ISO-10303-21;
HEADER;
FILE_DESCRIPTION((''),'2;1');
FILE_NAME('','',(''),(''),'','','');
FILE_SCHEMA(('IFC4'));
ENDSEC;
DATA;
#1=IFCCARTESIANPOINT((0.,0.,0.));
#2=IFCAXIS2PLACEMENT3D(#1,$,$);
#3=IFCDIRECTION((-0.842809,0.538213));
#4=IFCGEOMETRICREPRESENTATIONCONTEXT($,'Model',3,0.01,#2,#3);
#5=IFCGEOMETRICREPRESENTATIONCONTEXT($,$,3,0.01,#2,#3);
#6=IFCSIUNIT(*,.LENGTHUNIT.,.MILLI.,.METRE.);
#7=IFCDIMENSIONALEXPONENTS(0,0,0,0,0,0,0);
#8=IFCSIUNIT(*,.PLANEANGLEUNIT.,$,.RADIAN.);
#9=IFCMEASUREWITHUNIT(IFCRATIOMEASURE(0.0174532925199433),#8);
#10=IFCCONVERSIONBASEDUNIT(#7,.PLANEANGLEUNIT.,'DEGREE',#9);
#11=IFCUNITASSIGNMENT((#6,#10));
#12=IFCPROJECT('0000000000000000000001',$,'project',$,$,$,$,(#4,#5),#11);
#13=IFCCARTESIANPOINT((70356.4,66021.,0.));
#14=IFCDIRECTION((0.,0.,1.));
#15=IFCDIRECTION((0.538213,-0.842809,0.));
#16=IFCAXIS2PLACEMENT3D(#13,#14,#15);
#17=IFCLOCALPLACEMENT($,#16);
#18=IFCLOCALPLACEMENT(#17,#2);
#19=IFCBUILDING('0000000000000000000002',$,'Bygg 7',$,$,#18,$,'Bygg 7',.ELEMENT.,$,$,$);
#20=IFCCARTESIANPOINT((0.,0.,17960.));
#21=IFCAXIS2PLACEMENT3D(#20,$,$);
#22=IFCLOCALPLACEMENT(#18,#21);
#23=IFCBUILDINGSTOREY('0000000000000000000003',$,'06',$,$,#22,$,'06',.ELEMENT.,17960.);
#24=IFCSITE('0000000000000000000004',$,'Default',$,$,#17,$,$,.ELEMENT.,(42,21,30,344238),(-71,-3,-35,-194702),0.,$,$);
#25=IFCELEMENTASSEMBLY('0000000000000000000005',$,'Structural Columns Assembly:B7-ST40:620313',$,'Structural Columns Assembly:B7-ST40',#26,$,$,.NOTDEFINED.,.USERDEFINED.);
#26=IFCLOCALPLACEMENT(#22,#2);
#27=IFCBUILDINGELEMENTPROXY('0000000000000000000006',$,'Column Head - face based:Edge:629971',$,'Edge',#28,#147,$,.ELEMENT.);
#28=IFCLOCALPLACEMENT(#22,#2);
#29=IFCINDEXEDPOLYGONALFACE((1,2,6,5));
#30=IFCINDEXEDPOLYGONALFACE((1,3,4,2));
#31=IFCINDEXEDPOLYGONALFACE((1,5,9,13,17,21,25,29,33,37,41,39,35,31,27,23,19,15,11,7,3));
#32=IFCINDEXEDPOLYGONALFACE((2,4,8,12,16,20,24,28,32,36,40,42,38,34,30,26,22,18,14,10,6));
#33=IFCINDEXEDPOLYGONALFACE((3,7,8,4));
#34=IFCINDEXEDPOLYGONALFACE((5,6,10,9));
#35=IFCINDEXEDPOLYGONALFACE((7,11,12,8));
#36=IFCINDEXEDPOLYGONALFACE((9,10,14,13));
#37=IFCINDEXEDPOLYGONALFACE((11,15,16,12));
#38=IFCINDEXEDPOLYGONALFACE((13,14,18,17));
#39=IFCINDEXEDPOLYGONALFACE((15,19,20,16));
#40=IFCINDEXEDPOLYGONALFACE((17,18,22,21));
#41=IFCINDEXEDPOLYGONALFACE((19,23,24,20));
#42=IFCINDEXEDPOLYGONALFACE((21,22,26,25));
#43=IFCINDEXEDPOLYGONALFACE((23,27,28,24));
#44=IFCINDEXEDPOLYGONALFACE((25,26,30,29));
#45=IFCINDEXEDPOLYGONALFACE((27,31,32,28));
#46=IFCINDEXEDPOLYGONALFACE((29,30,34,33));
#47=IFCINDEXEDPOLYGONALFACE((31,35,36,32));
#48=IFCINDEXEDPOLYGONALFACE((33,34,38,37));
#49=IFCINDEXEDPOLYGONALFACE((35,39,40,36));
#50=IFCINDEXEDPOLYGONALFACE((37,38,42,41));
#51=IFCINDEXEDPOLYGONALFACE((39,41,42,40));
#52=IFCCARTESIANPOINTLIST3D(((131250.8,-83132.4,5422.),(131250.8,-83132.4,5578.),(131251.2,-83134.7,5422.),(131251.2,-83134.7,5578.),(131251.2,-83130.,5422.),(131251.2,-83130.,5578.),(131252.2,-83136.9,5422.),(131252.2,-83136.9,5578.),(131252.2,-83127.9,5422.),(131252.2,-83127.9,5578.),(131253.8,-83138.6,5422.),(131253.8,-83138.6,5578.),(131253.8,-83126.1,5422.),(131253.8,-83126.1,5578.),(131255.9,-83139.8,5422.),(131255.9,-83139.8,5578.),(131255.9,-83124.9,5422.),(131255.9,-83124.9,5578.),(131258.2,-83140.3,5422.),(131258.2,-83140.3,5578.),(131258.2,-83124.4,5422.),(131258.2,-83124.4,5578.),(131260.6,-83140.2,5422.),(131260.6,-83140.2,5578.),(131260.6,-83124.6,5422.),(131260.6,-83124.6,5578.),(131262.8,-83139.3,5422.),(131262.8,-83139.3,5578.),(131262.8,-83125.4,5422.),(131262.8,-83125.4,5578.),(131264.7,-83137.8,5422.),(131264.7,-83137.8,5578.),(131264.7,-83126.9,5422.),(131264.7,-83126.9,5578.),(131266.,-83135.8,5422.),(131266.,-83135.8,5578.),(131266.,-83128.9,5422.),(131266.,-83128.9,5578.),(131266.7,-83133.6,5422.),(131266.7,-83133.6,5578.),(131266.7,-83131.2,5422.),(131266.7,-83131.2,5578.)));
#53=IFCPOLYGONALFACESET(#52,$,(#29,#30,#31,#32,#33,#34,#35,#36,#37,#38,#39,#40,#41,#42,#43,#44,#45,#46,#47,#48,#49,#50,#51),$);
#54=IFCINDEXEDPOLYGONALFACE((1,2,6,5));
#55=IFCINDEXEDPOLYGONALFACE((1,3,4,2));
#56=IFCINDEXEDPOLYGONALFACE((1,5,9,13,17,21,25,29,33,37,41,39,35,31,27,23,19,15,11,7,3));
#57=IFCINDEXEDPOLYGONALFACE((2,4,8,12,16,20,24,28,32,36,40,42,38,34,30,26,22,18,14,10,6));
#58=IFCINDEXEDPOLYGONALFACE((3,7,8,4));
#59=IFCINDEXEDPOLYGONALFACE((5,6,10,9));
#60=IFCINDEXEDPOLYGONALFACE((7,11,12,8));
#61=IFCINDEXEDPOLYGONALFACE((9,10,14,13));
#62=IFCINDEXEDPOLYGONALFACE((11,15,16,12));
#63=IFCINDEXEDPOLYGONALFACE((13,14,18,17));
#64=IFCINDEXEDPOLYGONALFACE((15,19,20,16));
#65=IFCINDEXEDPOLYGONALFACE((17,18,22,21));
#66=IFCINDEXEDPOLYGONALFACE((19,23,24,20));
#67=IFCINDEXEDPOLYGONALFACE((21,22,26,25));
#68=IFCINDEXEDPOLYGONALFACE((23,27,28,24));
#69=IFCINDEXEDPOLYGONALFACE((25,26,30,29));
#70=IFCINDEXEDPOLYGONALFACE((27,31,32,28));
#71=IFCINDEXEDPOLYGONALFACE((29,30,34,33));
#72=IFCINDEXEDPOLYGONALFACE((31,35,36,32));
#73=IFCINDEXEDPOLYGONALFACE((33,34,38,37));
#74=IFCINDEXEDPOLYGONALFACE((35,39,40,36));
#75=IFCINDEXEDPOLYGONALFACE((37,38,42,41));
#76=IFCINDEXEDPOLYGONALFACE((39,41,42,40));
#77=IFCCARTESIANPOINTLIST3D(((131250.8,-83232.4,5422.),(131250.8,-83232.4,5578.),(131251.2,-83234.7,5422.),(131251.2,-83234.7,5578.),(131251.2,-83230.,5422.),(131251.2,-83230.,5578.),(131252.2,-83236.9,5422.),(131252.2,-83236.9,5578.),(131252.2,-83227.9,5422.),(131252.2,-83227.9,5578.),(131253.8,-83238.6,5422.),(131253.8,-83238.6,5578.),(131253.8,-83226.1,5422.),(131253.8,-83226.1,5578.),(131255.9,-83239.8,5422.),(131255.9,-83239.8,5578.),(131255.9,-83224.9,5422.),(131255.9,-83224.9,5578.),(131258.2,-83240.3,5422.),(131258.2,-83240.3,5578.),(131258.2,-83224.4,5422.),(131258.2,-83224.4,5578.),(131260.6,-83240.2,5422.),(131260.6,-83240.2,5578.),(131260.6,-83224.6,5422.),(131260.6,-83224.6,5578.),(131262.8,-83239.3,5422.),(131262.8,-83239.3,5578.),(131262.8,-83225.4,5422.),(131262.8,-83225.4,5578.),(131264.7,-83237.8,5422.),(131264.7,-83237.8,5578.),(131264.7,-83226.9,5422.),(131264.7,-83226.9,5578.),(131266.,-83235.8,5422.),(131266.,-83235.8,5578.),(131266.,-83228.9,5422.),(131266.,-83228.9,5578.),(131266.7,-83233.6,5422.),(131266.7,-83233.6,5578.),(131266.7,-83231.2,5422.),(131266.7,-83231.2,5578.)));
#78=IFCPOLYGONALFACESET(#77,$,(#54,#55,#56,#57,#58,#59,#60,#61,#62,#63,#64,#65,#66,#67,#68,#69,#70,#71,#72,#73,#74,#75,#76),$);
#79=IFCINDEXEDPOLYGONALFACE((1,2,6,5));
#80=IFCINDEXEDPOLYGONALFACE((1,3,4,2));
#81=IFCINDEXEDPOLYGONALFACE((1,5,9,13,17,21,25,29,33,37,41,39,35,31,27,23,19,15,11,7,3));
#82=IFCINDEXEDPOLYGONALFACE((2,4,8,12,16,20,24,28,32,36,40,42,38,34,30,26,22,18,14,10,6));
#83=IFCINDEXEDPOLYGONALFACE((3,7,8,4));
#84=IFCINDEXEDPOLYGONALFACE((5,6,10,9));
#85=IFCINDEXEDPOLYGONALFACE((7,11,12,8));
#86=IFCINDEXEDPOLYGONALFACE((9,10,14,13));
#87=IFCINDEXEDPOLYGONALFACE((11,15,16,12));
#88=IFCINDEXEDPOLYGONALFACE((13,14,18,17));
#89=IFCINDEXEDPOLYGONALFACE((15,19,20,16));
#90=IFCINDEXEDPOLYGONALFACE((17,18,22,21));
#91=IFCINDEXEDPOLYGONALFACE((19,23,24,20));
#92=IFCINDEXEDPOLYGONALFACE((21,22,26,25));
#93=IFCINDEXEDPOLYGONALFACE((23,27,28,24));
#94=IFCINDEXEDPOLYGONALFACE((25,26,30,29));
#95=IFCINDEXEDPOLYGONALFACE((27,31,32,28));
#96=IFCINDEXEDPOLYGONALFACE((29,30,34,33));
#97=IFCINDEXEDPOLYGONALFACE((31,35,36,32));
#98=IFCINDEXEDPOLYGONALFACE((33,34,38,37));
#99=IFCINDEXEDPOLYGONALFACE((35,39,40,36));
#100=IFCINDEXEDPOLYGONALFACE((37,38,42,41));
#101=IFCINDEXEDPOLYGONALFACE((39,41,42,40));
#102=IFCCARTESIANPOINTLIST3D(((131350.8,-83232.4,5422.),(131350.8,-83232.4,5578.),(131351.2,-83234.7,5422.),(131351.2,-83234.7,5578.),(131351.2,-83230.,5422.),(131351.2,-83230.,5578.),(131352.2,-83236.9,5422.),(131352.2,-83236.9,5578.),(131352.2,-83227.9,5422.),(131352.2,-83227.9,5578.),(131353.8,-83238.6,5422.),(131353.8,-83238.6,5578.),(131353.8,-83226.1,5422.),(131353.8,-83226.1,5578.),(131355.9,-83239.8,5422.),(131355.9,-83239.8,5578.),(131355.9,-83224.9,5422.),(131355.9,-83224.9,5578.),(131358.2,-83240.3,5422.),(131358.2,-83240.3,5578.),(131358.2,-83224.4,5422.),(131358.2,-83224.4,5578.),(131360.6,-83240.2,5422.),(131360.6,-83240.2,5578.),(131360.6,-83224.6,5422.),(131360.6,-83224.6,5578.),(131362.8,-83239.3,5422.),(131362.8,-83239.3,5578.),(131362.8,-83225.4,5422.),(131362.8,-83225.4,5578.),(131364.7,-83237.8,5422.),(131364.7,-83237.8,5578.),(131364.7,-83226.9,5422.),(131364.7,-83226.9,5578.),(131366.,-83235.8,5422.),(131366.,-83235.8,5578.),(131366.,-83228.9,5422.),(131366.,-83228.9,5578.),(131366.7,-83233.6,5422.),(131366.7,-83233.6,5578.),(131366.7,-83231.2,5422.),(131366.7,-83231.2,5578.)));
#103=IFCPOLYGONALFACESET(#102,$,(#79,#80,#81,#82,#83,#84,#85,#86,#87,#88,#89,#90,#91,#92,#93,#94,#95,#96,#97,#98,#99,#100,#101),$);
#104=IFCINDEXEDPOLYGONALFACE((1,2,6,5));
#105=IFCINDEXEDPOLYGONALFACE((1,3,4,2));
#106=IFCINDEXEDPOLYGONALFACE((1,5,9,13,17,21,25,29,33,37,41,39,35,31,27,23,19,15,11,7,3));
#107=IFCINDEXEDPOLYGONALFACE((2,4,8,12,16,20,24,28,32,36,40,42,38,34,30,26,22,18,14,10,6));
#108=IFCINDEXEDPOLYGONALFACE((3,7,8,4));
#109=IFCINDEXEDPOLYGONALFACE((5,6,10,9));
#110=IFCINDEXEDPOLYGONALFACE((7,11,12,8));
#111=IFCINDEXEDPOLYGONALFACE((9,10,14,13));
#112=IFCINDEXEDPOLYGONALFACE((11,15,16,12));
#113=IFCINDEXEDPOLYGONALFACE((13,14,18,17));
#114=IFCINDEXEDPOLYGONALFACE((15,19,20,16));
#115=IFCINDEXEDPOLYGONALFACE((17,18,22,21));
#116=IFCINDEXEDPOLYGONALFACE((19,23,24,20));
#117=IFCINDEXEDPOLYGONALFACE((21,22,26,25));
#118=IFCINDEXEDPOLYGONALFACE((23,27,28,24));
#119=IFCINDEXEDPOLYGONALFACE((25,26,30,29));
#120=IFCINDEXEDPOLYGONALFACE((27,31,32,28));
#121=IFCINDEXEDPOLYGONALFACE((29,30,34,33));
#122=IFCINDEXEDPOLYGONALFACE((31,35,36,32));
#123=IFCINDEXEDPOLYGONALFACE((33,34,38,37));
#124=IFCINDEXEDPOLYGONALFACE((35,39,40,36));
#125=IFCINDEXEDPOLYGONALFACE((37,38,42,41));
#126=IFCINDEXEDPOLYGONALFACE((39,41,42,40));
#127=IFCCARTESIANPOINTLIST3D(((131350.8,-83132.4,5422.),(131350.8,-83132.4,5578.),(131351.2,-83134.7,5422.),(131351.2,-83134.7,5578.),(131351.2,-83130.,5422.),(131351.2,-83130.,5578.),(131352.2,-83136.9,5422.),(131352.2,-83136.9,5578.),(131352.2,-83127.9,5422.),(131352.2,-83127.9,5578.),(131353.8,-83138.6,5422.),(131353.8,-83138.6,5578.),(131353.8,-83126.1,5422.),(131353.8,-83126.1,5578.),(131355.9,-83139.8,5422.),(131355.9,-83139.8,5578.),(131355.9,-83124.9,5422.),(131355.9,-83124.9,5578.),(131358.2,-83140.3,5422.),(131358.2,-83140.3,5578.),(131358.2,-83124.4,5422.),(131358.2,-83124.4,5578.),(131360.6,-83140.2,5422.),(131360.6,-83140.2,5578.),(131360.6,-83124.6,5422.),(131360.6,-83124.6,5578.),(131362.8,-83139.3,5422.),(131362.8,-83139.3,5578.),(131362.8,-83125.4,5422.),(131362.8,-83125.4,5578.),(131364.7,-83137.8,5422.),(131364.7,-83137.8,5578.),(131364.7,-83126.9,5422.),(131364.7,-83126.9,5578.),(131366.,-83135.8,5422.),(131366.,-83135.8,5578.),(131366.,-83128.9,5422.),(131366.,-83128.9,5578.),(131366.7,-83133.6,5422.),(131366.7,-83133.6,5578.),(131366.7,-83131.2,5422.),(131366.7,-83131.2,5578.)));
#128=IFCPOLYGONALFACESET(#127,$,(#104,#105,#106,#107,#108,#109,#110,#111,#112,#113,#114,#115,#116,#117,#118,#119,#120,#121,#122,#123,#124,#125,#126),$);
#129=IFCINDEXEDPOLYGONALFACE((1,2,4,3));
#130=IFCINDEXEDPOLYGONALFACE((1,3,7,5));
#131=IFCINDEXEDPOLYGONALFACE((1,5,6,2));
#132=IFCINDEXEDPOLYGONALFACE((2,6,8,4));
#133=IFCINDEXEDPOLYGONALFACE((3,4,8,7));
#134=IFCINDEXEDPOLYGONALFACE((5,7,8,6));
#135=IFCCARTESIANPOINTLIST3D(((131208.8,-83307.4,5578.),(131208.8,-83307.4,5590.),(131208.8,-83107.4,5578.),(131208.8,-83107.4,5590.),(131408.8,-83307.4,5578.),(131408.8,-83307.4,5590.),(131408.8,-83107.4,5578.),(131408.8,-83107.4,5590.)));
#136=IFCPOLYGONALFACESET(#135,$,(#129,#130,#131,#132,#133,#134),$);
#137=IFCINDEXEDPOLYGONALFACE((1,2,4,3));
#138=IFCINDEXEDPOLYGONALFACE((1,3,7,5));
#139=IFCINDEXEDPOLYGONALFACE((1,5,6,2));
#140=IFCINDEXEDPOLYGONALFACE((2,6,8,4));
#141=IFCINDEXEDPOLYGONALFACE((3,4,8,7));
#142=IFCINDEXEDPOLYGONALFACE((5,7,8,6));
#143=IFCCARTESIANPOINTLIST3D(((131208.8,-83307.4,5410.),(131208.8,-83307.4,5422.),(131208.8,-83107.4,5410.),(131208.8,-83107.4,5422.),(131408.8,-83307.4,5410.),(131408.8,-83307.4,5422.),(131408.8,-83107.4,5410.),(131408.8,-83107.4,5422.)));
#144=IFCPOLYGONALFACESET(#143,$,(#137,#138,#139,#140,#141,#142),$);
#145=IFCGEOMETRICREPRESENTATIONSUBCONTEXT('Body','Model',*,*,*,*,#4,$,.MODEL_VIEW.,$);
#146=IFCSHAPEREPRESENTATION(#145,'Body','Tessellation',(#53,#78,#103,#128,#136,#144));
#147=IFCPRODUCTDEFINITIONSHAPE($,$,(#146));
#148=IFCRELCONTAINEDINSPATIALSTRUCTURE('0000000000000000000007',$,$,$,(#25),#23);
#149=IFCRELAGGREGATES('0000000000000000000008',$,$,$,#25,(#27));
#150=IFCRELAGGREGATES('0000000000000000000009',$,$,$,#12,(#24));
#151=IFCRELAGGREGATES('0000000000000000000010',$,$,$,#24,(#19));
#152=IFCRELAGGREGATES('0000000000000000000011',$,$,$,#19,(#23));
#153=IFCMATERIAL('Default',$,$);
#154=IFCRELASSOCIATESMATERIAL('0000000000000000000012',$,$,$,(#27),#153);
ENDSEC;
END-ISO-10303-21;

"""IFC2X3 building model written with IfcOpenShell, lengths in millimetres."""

from ifc_helpers import new_model, entity, si_unit, converted_unit, direction, frame, frame_2d, origin, origin_2d_with_axis, place, context, subcontext, project, spatial, rectangle, circle, extrude, source, transform, mapped, material, element, aggregate, save


model = new_model("IFC2X3")

# Units and contexts
model_context = context("Model", 3, precision=0.01, world=origin(), true_north=direction((-0.842809, 0.538213)))
context_of_model = context(None, 3, precision=0.01, world=origin(), true_north=direction((-0.842809, 0.538213)))
body_context = subcontext(model_context, "Body", "Model", "MODEL_VIEW")
ifc_project = project(units=[si_unit("LENGTHUNIT", "METRE", prefix="MILLI"), converted_unit("PLANEANGLEUNIT", "DEGREE", entity("IfcRatioMeasure", 0.0174532925199433), si_unit("PLANEANGLEUNIT", "RADIAN"), dimensions=[0, 0, 0, 0, 0, 0, 0])], contexts=[model_context, context_of_model])

# Site, building, storey
site_placement = place(None, frame((70356.4, 66021.0, 0.0), z_axis=(0.0, 0.0, 1.0), x_axis=(0.538213, -0.842809, 0.0)))
site = spatial("IfcSite", under=ifc_project, at=site_placement, Name="Default", CompositionType="ELEMENT", RefLatitude=(42, 21, 30, 344238), RefLongitude=(-71, -3, -35, -194702), RefElevation=0.0)
building_placement = place(site_placement, origin())
building = spatial("IfcBuilding", under=site, at=building_placement, Name="Bygg 7", LongName="Bygg 7", CompositionType="ELEMENT")
storey_placement = place(building_placement, frame((0.0, 0.0, 17960.0)))
storey = spatial("IfcBuildingStorey", under=building, at=storey_placement, Name="06", LongName="06", CompositionType="ELEMENT", Elevation=17960.0)

# Element assembly
assembly_1_placement = place(storey_placement, origin())
assembly_1 = element("IfcElementAssembly", 1, at=assembly_1_placement, inside=storey, Name="Structural Columns Assembly:B7-ST40:620313", ObjectType="Structural Columns Assembly:B7-ST40", AssemblyPlace="NOTDEFINED", PredefinedType="USERDEFINED")

# Building element proxy
ifc_material_1 = material(Name="Default")
shared_shape_1 = source(origin(), body_context, "Body", "SweptSolid", [
    extrude(circle(Radius=8.0, at=frame_2d((0.0, 0.0), x_axis=(1.0, 0.0))), frame((50.0, -135.0, 12.0)), (0.0, 0.0, 1.0), 156.0),
    extrude(circle(Radius=8.0, at=frame_2d((0.0, 0.0), x_axis=(1.0, 0.0))), frame((50.0, -35.0, 12.0)), (0.0, 0.0, 1.0), 156.0),
    extrude(circle(Radius=8.0, at=frame_2d((0.0, 0.0), x_axis=(1.0, 0.0))), frame((-50.0, -35.0, 12.0)), (0.0, 0.0, 1.0), 156.0),
    extrude(circle(Radius=8.0, at=frame_2d((0.0, 0.0), x_axis=(1.0, 0.0))), frame((-50.0, -135.0, 12.0)), (0.0, 0.0, 1.0), 156.0),
    extrude(rectangle(XDim=200.0, YDim=200.0, at=origin_2d_with_axis()), frame((0.0, -60.0, 168.0), z_axis=(0.0, 0.0, 1.0), x_axis=(-1.0, 0.0, 0.0)), (0.0, 0.0, 1.0), 12.0),
    extrude(rectangle(XDim=200.0, YDim=200.0, at=origin_2d_with_axis()), frame((0.0, -60.0, 0.0), z_axis=(0.0, 0.0, 1.0), x_axis=(0.0, 1.0, 0.0)), (0.0, 0.0, 1.0), 12.0),
])
proxy_1_placement = place(assembly_1_placement, frame((131308.8, -83267.4, 5410.0), z_axis=(0.0, 0.0, 1.0), x_axis=(-1.0, 0.0, 0.0)))
proxy_1 = element("IfcBuildingElementProxy", 2, at=proxy_1_placement, material=ifc_material_1, Name="Column Head - face based:Edge:629971", ObjectType="Edge", CompositionType="ELEMENT", context=body_context, shape_type="MappedRepresentation", body=[
    mapped(shared_shape_1, transform((0.0, 0.0, 0.0), scale=1.0)),
])
aggregate(assembly_1, [proxy_1])

save(model, "model.ifc")
